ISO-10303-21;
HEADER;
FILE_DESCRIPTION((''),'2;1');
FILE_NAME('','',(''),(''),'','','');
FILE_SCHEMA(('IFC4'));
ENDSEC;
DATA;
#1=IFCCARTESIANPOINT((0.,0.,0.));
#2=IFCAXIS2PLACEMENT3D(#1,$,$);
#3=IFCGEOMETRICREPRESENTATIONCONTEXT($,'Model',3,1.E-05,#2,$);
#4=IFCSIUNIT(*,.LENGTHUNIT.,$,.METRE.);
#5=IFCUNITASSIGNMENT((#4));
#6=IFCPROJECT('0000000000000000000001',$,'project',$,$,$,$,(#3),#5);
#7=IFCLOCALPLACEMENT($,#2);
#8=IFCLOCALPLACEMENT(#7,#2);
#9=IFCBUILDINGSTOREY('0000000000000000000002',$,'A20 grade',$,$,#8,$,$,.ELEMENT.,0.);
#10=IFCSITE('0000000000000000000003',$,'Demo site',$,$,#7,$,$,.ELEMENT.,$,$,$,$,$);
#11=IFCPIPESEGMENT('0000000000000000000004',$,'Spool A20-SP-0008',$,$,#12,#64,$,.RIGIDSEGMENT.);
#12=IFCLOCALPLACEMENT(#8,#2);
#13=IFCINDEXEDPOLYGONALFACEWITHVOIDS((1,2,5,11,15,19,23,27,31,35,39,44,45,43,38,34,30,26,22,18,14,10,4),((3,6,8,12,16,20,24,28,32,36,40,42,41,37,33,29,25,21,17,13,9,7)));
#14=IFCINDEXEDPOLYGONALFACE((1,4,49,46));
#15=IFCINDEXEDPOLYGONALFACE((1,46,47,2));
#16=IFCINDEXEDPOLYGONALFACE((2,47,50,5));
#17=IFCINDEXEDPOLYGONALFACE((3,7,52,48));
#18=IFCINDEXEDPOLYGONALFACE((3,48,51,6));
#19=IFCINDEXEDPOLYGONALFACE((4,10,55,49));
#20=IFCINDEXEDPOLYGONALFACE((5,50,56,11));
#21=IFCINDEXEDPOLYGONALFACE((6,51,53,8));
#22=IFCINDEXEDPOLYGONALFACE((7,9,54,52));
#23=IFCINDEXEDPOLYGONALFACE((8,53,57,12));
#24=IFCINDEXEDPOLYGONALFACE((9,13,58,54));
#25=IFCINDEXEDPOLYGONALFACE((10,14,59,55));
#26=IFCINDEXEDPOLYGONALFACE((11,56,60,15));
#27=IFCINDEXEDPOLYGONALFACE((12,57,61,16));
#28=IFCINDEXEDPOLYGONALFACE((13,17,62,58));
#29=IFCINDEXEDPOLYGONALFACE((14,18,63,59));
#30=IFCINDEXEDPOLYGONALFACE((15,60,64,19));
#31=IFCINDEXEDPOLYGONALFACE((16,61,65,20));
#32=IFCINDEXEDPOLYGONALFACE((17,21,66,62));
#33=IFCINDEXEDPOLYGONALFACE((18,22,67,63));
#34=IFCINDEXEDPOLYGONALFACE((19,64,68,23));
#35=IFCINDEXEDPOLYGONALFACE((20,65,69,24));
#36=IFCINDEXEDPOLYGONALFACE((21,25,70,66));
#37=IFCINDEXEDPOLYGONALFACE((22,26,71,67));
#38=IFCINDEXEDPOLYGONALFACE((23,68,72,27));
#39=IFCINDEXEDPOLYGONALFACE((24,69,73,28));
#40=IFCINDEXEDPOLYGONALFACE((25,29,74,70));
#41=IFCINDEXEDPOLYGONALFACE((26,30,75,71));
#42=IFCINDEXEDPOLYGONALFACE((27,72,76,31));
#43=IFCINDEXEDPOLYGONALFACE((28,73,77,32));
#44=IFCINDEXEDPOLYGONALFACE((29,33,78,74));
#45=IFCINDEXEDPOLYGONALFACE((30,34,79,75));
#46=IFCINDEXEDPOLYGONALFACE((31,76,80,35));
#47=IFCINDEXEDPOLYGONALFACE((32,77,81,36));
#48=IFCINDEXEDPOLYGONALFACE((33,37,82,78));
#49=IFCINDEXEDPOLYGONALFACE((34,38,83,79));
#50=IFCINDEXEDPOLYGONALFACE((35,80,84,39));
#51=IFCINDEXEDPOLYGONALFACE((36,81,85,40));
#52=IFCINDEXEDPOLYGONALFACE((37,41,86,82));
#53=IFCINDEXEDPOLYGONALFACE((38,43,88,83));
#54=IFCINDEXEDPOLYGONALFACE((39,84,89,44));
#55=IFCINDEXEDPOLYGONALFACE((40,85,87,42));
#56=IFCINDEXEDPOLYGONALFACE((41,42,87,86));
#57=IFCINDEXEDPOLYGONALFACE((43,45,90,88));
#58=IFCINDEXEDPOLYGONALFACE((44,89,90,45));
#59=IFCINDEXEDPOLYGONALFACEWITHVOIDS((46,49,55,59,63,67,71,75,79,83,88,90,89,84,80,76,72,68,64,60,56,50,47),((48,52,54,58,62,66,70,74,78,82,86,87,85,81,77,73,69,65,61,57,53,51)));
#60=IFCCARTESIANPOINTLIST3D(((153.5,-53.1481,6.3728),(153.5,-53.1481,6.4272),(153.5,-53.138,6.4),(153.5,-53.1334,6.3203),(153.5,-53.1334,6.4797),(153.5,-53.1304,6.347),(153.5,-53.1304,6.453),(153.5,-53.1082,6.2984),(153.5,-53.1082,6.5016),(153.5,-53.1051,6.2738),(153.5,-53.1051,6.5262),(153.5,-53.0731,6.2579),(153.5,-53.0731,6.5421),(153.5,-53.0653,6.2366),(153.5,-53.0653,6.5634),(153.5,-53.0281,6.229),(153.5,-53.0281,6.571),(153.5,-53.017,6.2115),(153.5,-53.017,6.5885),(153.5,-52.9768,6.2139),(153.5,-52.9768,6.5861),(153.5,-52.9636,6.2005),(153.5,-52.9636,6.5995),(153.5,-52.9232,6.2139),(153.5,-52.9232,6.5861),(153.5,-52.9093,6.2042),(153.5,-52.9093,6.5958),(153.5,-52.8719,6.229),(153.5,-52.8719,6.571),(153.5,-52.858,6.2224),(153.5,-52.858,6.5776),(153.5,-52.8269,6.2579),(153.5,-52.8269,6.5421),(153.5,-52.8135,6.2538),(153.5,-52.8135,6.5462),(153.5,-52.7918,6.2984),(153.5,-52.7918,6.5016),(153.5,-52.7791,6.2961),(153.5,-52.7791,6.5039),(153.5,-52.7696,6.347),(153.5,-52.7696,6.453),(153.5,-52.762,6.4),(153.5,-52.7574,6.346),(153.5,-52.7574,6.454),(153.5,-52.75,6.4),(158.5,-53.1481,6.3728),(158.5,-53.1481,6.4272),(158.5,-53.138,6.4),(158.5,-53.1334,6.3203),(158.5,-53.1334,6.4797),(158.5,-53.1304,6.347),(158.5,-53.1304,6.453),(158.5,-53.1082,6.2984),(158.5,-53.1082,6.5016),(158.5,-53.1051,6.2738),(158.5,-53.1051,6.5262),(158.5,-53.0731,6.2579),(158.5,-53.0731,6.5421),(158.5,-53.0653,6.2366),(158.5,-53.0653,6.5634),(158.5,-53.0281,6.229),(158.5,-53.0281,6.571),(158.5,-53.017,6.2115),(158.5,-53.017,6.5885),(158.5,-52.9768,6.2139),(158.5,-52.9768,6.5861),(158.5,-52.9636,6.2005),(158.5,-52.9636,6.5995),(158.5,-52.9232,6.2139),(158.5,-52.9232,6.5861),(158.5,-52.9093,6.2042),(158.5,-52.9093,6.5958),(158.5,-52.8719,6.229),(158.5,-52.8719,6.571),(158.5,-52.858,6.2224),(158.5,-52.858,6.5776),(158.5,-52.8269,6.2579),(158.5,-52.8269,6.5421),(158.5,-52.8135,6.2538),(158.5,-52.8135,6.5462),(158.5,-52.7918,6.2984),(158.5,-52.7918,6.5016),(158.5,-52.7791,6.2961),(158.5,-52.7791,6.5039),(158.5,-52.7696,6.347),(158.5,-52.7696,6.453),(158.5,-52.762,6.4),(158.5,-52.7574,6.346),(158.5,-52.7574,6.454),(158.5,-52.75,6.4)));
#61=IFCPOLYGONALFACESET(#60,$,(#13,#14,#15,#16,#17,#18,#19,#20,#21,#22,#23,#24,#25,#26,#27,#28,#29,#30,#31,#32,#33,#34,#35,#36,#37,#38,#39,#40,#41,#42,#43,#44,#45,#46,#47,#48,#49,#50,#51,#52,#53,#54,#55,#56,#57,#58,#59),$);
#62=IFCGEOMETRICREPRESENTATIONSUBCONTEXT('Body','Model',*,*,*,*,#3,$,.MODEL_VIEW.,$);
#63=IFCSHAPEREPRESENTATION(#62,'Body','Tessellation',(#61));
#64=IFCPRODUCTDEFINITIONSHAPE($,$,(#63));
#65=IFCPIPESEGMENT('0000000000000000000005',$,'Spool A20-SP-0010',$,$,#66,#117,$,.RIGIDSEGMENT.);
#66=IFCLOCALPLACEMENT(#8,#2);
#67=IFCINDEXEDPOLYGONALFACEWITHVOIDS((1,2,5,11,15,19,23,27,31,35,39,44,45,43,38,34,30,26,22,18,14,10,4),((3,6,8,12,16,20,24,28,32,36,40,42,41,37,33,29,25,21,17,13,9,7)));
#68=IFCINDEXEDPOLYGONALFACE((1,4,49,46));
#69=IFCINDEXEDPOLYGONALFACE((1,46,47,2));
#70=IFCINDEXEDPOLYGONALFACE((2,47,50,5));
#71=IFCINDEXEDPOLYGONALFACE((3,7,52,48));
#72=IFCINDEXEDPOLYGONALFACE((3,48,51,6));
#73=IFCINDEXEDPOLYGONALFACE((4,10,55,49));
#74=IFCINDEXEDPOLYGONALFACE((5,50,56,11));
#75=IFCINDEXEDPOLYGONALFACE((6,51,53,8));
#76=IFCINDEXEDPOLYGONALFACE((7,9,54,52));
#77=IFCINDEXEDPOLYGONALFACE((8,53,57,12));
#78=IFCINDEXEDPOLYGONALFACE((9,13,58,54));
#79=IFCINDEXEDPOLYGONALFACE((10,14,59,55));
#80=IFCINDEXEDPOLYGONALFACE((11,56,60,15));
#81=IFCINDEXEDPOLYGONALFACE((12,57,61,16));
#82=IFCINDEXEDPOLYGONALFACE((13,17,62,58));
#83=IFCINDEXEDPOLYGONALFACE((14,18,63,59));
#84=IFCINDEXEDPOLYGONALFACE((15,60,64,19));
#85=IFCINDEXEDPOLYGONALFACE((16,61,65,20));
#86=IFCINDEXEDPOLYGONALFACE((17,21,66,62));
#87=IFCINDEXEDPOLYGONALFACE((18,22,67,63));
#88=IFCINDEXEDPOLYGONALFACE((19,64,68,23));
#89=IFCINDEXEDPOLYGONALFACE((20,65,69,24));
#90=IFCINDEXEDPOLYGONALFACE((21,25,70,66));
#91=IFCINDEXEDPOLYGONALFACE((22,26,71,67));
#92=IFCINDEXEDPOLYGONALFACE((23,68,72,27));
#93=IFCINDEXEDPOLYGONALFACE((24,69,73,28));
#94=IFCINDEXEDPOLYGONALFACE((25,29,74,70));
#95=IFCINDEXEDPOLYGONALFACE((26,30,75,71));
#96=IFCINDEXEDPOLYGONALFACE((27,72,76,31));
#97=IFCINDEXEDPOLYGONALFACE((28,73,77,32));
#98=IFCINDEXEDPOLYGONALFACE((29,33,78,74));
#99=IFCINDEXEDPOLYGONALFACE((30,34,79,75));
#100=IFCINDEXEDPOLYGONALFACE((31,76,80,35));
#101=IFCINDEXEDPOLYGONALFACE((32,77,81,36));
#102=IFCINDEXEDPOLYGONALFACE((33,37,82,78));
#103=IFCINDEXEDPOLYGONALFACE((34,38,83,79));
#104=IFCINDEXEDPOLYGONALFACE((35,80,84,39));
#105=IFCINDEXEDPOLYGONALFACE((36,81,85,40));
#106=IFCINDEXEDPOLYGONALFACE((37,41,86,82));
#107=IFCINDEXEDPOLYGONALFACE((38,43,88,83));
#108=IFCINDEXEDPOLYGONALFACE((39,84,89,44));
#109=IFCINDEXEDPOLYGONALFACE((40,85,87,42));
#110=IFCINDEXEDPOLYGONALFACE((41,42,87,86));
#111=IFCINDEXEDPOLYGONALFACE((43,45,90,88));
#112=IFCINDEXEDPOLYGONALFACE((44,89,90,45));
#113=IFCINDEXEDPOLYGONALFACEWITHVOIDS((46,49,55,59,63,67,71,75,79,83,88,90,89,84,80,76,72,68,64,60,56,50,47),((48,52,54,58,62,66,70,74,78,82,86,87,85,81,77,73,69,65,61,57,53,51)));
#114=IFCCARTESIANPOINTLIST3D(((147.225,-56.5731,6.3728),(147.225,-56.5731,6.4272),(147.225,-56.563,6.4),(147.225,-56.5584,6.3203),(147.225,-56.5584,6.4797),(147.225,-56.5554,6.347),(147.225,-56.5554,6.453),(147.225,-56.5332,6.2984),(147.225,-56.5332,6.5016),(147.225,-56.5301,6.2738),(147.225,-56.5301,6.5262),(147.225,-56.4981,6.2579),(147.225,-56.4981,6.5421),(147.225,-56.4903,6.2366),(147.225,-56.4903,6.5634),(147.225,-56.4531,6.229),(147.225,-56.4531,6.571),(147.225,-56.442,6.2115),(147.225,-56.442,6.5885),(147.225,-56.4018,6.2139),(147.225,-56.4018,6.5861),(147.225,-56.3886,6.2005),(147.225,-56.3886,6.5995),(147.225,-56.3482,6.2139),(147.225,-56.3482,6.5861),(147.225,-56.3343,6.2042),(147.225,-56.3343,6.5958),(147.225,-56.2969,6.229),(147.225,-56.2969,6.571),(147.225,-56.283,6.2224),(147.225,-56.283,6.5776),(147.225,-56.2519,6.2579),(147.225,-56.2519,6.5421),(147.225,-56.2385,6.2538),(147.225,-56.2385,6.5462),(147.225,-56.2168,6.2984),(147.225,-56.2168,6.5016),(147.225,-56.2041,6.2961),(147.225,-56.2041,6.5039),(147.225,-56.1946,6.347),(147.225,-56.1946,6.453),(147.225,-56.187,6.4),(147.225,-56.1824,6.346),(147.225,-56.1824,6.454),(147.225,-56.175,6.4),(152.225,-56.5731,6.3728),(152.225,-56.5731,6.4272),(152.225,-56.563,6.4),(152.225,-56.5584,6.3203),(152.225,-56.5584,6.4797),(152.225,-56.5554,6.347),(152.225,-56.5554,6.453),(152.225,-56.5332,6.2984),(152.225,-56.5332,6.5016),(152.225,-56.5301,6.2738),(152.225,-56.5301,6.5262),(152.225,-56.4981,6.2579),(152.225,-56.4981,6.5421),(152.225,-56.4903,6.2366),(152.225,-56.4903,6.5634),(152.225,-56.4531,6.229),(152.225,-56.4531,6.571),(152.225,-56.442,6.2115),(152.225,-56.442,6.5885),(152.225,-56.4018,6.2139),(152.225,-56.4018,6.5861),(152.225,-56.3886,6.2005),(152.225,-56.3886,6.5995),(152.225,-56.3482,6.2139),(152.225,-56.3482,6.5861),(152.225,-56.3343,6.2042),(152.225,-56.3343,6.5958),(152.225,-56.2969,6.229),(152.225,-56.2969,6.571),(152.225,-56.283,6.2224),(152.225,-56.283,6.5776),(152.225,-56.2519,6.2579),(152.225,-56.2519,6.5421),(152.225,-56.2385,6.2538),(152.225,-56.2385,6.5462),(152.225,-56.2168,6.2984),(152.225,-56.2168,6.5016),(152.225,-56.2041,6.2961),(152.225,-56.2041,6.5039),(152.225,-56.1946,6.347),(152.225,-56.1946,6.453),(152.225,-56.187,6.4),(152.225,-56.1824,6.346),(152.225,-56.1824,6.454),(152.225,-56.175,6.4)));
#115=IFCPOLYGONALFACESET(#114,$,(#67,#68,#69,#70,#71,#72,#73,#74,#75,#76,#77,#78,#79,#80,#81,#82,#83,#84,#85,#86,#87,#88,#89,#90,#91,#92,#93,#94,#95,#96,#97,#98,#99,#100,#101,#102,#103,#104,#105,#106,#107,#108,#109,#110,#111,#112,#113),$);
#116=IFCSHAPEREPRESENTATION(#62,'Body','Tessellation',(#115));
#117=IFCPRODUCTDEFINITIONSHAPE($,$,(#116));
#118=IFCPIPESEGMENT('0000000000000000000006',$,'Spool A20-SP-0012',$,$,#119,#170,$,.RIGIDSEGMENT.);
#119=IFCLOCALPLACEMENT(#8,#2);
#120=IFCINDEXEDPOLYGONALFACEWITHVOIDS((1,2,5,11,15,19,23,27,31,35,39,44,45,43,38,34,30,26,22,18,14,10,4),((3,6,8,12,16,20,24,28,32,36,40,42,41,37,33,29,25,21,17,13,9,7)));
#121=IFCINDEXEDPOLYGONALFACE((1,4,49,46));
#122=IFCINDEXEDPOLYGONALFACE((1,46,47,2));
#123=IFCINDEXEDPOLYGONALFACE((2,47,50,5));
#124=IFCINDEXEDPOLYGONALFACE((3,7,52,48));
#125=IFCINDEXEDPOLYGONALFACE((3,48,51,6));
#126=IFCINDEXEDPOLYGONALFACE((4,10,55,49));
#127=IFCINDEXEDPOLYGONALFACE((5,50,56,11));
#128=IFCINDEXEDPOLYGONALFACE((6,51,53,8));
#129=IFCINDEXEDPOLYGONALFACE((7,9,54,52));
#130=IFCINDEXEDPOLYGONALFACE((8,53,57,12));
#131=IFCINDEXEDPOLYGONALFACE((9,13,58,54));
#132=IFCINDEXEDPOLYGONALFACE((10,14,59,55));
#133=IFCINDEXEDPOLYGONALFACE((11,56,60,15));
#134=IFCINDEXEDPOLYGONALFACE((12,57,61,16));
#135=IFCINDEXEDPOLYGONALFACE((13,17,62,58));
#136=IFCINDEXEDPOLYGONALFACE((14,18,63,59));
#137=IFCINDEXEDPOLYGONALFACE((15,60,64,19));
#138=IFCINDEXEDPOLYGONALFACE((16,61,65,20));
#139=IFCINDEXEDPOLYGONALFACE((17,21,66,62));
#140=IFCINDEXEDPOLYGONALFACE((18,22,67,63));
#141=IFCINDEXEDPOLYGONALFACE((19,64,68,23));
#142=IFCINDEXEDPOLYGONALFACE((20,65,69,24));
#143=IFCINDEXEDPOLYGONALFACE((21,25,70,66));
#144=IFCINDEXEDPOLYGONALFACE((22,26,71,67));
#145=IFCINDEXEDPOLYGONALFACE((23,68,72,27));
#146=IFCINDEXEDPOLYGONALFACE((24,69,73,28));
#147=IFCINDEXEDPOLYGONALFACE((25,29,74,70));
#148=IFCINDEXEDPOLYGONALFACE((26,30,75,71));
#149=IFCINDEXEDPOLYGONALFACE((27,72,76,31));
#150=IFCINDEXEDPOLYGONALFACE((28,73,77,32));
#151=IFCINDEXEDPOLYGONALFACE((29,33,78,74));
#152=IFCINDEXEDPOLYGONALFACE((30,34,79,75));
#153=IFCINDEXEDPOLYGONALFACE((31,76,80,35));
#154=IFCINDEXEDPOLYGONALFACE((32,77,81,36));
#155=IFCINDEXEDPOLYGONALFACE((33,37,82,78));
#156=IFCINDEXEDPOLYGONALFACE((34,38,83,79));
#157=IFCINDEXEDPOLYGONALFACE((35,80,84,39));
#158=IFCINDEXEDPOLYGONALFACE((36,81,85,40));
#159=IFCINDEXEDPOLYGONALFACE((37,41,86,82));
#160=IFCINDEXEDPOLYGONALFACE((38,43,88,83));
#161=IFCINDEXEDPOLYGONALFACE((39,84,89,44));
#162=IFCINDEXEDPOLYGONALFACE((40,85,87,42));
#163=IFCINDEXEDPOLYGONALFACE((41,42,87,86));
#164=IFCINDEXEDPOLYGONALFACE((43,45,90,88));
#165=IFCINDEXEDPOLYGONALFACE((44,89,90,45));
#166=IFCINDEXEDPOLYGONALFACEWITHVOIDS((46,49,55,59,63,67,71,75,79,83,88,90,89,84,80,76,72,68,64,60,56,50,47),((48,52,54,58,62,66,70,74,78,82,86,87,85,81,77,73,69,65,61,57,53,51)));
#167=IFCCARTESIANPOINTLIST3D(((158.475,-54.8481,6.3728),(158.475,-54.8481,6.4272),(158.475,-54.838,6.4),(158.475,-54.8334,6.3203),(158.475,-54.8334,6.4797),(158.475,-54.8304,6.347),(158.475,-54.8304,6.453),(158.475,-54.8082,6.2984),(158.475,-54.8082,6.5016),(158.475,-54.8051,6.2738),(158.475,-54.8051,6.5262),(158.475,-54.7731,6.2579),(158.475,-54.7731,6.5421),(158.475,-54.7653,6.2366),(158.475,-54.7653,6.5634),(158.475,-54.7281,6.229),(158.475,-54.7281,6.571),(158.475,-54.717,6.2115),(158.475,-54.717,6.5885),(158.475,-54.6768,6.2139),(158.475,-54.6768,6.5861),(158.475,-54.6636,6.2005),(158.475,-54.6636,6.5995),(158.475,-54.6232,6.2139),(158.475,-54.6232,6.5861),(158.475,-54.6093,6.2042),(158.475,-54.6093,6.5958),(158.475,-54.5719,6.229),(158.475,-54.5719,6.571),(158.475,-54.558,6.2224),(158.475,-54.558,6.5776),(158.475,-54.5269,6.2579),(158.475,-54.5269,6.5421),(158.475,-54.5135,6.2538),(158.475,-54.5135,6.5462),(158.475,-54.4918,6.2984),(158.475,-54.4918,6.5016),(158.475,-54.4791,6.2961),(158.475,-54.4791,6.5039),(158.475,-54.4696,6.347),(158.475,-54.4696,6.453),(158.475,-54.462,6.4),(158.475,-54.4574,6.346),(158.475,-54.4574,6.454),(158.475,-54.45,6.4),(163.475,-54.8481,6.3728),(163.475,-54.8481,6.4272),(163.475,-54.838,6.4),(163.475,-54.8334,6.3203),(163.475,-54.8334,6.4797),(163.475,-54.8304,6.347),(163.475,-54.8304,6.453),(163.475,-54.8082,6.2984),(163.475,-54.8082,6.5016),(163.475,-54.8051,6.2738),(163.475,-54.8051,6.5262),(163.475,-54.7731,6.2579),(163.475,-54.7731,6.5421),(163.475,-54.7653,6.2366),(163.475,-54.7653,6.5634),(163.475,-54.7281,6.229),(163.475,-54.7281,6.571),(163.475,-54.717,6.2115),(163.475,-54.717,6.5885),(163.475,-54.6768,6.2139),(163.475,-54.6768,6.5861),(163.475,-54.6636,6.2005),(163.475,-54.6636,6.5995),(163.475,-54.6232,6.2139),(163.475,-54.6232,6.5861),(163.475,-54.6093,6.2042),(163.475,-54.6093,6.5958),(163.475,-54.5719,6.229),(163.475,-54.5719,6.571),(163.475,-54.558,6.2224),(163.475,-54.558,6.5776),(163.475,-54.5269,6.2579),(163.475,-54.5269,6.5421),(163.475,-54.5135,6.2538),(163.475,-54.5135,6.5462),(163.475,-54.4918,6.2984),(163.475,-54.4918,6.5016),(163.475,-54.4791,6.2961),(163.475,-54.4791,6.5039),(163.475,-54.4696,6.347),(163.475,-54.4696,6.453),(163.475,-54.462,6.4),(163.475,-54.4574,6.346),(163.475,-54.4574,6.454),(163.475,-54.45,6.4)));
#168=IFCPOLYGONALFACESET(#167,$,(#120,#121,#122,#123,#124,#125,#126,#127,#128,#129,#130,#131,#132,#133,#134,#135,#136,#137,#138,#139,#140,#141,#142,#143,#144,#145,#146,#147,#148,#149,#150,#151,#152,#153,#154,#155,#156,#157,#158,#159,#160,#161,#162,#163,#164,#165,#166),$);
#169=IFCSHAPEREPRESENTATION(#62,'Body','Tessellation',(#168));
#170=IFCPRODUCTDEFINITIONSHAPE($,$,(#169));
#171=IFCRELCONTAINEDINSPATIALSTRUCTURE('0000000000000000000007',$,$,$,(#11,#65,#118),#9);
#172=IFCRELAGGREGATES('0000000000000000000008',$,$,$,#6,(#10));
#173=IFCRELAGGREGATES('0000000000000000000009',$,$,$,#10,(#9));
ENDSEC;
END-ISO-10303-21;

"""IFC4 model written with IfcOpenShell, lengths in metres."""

from ifc_helpers import new_model, si_unit, frame, origin, place, context, subcontext, project, spatial, hollow_circle, extrude, element, save


model = new_model("IFC4")

# Units and contexts
model_context = context("Model", 3, precision=1e-05, world=origin())
body_context = subcontext(model_context, "Body", "Model", "MODEL_VIEW")
ifc_project = project(units=[si_unit("LENGTHUNIT", "METRE")], contexts=[model_context])

# Site, storey
site_placement = place(None, origin())
site = spatial("IfcSite", under=ifc_project, at=site_placement, Name="Demo site", CompositionType="ELEMENT")
storey_placement = place(site_placement, origin())
storey = spatial("IfcBuildingStorey", under=site, at=storey_placement, Name="A20 grade", CompositionType="ELEMENT", Elevation=0.0)

# Pipe segments
for number, where, name in (
    (1, (153.5, -52.95, 6.4), "Spool A20-SP-0008"),
    (2, (147.225, -56.375, 6.4), "Spool A20-SP-0010"),
    (3, (158.475, -54.65, 6.4), "Spool A20-SP-0012"),
):
    element("IfcPipeSegment", number, at=place(storey_placement, frame(where)), inside=storey, Name=name, PredefinedType="RIGIDSEGMENT", context=body_context, shape_type="SweptSolid", body=[
        extrude(hollow_circle(Radius=0.2, WallThickness=0.012), frame((0.0, 0.0, 0.0), z_axis=(1.0, 0.0, 0.0), x_axis=(0.0, 1.0, 0.0)), (0.0, 0.0, 1.0), 5.0),
    ])

save(model, "model.ifc")
